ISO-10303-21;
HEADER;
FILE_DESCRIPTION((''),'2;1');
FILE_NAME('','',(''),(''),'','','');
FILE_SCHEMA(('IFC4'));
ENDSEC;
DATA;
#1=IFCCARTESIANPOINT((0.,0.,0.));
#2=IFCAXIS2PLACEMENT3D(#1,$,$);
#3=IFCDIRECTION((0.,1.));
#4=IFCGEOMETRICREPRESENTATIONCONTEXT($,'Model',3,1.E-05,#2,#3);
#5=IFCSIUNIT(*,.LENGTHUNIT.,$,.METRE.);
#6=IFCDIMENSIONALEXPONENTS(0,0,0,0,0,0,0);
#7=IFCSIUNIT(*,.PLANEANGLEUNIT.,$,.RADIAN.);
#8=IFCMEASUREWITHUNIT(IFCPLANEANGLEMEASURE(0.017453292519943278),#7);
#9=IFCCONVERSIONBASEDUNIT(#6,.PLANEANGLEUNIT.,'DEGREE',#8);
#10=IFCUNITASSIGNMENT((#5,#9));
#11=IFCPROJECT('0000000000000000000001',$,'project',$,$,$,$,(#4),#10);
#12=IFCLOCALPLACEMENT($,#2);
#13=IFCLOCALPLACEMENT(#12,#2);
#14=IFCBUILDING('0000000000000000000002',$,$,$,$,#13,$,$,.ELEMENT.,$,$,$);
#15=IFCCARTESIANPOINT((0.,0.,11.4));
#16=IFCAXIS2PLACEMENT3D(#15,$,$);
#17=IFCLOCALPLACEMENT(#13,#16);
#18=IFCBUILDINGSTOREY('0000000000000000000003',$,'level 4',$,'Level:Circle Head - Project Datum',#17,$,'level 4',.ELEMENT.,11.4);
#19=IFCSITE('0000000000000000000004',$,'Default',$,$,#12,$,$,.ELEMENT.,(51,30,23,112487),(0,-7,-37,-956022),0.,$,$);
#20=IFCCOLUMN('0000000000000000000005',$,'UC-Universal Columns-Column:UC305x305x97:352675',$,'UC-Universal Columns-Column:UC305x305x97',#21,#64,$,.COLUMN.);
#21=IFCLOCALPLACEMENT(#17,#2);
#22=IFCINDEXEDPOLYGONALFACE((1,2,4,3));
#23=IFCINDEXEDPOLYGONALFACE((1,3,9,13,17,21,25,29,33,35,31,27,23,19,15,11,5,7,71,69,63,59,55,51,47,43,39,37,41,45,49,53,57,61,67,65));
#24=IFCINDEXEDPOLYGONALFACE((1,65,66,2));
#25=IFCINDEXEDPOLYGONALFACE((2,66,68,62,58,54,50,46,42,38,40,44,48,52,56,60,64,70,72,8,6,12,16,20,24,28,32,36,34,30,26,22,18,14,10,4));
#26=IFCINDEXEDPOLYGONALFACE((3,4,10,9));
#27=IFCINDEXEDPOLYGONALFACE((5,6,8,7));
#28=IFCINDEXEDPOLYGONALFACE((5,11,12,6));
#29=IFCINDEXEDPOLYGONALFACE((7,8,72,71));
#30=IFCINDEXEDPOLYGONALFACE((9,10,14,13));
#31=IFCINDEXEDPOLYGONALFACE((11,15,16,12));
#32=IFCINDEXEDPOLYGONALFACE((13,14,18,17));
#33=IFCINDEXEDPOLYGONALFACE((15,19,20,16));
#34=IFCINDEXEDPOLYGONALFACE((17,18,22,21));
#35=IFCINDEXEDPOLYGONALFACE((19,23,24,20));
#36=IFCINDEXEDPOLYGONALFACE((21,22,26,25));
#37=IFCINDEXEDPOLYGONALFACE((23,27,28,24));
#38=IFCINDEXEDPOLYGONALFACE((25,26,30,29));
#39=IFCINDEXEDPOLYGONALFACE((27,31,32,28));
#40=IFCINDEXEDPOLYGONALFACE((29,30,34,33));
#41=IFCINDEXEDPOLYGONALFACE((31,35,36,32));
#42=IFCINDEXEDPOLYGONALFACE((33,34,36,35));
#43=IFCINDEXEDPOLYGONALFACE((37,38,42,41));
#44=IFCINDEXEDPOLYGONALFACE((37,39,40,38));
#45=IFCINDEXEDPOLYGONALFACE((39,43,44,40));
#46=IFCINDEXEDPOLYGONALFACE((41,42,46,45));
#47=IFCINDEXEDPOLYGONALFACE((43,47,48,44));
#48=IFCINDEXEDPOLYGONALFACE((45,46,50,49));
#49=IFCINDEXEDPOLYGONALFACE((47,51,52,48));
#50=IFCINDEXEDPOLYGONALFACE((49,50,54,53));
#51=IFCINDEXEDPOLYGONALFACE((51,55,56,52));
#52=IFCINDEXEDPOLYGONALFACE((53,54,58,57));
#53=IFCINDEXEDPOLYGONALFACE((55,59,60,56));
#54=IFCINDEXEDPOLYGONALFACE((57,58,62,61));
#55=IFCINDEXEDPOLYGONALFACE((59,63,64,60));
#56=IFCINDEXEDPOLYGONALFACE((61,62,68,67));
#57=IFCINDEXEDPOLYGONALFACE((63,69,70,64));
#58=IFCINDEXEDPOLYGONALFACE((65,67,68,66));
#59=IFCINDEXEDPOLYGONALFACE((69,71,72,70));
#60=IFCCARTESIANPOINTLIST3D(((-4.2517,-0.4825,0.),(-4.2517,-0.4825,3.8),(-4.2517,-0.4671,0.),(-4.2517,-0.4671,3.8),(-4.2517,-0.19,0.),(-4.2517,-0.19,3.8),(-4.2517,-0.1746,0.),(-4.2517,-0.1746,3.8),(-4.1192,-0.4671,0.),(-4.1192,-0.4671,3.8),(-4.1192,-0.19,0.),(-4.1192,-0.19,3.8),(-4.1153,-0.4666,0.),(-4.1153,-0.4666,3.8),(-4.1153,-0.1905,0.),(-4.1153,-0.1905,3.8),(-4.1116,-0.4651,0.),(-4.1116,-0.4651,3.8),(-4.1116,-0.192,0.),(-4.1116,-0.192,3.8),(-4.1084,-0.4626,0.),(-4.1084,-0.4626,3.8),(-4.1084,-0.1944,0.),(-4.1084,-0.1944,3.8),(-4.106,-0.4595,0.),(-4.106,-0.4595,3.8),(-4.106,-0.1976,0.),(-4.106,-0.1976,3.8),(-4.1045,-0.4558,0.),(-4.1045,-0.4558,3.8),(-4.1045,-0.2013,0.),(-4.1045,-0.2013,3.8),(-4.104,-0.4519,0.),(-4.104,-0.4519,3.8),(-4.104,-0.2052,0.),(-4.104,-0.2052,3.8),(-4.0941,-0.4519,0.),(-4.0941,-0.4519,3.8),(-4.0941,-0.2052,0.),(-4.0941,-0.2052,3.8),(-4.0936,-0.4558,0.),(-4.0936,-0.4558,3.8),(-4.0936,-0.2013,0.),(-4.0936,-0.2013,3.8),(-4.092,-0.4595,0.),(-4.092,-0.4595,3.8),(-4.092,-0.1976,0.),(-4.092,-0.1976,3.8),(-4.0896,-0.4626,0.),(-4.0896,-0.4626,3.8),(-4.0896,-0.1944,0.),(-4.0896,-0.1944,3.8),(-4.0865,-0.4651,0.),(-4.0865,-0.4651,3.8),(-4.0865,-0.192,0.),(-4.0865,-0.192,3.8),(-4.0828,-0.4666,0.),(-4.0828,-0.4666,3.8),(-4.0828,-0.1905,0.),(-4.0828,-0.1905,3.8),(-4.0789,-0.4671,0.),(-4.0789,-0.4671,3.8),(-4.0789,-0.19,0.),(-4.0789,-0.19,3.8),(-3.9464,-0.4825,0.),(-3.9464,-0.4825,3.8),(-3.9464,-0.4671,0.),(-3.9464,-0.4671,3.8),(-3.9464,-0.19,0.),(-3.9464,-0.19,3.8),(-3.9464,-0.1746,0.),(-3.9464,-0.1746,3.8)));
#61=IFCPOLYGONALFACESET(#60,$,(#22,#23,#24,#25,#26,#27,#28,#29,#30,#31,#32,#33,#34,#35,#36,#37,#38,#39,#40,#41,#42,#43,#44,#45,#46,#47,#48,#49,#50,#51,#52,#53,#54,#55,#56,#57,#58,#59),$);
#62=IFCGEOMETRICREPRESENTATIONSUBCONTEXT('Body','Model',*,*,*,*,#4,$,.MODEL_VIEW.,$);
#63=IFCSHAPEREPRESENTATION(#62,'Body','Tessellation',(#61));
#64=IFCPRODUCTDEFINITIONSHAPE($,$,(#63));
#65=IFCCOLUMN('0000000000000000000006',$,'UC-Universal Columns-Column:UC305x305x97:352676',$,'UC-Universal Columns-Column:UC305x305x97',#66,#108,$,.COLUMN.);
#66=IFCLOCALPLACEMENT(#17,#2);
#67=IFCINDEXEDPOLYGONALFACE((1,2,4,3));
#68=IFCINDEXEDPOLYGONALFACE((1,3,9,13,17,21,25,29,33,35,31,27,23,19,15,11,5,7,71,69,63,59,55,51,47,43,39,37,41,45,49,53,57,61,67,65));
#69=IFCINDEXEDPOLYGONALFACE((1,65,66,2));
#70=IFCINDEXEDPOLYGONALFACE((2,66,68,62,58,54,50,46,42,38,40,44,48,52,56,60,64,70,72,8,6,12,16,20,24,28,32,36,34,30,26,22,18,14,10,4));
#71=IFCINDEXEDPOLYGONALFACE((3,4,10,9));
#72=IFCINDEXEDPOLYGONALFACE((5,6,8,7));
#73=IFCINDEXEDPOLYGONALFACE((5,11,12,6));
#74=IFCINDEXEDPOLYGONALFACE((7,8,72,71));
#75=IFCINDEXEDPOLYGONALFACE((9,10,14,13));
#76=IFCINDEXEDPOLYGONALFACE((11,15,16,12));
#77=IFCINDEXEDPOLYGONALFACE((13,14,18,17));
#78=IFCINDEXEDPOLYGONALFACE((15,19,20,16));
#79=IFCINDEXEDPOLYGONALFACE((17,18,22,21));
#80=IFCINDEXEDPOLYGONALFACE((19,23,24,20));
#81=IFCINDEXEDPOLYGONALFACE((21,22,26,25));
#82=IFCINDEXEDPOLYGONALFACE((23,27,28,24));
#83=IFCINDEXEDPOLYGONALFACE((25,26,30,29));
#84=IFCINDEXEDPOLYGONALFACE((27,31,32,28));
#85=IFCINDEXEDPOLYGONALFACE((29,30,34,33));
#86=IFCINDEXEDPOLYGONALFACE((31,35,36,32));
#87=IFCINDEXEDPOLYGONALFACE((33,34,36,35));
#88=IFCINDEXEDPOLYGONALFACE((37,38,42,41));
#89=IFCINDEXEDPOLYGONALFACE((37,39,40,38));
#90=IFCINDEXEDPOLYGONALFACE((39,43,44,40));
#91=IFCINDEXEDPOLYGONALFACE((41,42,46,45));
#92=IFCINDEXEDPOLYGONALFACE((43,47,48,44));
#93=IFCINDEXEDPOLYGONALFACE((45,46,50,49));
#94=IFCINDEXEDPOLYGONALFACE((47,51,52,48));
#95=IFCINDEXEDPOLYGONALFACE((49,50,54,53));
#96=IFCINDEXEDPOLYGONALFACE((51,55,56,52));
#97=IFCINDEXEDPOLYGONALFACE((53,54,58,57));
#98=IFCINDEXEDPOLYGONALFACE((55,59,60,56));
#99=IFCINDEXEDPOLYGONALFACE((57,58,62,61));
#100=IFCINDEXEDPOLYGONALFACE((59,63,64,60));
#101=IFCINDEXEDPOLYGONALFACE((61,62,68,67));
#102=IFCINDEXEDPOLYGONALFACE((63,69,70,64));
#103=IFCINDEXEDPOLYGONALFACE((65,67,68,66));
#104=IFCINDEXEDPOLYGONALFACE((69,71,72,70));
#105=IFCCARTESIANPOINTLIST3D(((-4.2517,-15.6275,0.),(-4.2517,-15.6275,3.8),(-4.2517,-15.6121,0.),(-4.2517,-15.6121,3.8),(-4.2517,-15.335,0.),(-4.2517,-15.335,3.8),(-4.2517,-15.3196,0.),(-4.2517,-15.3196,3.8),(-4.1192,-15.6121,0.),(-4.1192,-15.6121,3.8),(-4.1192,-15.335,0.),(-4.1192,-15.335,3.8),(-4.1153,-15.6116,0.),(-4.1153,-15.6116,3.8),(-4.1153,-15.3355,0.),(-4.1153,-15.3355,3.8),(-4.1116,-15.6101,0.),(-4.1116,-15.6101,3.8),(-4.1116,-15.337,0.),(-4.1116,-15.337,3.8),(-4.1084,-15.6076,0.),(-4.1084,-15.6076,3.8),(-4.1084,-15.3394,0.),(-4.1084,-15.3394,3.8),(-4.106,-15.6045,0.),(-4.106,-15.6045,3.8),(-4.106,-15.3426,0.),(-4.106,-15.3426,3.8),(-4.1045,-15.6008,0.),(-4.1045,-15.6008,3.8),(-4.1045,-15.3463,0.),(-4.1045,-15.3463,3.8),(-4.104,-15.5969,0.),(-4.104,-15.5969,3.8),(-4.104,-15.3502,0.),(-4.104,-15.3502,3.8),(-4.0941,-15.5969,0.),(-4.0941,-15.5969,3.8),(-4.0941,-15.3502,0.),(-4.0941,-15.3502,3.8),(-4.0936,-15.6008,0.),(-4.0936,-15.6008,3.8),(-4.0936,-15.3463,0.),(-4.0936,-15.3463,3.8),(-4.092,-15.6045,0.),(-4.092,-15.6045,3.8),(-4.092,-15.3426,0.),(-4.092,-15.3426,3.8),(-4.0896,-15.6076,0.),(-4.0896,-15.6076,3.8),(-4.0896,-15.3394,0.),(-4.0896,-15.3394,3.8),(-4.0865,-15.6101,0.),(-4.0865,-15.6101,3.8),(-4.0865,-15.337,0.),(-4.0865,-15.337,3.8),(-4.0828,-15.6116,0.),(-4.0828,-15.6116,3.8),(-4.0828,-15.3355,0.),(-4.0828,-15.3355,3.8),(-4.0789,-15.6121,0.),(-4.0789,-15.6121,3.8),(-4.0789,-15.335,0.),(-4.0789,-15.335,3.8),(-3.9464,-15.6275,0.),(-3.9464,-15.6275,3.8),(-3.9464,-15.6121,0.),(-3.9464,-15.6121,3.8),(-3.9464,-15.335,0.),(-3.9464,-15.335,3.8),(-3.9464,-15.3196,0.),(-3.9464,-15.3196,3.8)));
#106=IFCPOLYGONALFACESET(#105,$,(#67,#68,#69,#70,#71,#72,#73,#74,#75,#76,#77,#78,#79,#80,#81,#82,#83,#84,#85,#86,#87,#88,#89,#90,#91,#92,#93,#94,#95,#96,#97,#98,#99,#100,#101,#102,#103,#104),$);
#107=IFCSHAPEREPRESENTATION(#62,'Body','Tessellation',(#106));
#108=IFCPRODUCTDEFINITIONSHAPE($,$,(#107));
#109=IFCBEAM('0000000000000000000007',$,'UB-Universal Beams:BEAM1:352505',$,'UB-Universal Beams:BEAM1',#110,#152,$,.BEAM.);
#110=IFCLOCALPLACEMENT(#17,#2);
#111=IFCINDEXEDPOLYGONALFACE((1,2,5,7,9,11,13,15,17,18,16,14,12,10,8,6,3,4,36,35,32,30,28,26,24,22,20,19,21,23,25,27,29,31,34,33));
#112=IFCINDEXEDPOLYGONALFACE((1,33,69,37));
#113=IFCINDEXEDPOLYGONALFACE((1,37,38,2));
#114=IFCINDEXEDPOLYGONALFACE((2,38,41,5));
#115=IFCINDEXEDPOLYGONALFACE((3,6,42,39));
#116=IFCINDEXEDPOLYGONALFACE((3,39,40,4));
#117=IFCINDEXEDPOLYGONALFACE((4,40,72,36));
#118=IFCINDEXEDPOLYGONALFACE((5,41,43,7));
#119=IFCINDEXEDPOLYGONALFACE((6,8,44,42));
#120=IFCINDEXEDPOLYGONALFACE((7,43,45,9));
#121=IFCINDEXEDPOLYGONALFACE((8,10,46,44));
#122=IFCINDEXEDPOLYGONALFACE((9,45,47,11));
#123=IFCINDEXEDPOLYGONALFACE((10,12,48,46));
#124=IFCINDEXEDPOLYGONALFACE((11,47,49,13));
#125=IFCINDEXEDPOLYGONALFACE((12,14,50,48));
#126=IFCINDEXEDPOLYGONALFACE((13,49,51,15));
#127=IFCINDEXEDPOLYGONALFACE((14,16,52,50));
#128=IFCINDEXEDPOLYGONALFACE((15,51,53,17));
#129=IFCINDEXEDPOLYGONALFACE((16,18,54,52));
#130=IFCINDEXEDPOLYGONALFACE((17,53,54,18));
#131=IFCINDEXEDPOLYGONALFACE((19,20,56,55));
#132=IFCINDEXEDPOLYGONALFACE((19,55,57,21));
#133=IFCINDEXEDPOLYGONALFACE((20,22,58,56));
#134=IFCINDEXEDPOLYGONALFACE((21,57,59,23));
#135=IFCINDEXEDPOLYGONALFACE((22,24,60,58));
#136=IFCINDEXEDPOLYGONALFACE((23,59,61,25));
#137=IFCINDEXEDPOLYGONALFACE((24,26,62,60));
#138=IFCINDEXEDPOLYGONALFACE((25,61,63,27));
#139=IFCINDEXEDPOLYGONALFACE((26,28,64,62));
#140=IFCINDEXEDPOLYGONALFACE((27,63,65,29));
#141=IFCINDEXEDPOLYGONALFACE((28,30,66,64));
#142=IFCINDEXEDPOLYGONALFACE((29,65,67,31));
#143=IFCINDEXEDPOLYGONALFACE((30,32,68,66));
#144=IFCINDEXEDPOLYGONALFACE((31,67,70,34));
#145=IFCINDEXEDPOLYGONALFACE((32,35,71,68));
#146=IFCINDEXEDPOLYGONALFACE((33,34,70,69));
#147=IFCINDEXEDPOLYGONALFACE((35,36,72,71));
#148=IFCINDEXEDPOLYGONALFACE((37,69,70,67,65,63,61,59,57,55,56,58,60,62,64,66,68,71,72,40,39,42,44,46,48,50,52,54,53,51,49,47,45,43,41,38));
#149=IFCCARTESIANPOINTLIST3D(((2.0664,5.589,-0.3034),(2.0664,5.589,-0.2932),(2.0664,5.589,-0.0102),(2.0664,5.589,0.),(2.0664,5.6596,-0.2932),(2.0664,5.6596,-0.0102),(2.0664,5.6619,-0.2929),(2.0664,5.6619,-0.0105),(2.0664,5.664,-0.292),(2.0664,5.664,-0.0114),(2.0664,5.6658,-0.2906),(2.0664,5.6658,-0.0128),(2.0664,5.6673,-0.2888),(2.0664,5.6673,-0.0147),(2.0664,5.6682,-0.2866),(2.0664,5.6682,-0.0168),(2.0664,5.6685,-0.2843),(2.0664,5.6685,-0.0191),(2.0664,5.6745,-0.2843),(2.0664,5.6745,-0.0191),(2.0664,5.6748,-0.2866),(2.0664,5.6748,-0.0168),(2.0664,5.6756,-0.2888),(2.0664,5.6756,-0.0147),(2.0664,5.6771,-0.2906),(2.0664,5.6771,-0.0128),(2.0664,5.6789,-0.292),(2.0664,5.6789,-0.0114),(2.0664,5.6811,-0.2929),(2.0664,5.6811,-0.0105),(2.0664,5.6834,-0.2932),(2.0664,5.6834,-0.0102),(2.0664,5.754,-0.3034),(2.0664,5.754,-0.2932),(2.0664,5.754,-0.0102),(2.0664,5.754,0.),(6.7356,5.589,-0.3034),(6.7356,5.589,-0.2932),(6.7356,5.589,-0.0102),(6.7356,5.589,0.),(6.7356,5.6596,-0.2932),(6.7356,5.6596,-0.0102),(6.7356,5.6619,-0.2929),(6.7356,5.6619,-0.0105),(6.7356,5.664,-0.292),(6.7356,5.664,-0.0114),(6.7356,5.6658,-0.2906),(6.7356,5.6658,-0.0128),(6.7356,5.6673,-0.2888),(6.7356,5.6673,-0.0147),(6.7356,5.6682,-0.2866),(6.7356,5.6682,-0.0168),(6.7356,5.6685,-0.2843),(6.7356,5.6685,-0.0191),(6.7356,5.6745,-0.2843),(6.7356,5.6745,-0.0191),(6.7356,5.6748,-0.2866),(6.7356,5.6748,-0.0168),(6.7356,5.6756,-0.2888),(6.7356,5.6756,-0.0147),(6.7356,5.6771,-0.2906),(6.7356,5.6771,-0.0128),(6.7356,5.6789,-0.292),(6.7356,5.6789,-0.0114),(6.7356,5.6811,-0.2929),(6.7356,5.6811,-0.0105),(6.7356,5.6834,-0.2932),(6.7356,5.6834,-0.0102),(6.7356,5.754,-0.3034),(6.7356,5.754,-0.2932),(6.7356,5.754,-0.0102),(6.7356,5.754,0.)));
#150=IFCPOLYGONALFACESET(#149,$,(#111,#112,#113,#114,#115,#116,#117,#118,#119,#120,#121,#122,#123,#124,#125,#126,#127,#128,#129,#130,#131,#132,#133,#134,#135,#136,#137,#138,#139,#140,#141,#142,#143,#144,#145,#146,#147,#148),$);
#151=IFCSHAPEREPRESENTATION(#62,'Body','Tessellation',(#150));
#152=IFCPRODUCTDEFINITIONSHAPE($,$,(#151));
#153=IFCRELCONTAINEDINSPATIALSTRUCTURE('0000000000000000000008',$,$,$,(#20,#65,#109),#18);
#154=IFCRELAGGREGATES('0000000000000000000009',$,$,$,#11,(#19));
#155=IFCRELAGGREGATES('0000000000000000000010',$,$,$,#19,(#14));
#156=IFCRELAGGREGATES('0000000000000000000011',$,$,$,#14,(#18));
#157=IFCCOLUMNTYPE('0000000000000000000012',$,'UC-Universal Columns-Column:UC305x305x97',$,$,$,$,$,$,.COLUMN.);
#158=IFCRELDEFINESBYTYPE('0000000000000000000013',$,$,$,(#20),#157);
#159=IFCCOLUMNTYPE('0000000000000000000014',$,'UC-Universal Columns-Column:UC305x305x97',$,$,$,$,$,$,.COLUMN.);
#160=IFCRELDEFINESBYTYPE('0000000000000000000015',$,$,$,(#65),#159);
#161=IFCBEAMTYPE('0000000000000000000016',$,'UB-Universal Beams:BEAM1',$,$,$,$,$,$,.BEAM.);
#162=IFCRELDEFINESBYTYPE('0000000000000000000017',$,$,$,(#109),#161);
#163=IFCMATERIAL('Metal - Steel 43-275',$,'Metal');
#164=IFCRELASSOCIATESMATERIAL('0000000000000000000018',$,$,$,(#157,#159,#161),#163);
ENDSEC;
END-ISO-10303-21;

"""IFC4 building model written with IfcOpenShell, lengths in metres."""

from ifc_helpers import new_model, entity, si_unit, converted_unit, direction, frame, frame_2d, origin, place, context, subcontext, project, spatial, polyline, circle_curve, parameter, trimmed, segment, composite_curve, i_section, outline, extrude, source, transform, mapped, material, material_profile, profile_set, type_object, type_shapes, element, save


model = new_model("IFC4")

# Units and contexts
model_context = context("Model", 3, precision=1e-05, world=origin(), true_north=direction((0.0, 1.0)))
body_context = subcontext(model_context, "Body", "Model", "MODEL_VIEW")
ifc_project = project(units=[si_unit("LENGTHUNIT", "METRE"), converted_unit("PLANEANGLEUNIT", "DEGREE", entity("IfcPlaneAngleMeasure", 0.017453292519943278), si_unit("PLANEANGLEUNIT", "RADIAN"), dimensions=[0, 0, 0, 0, 0, 0, 0])], contexts=[model_context])

# Site, building, storey
site_placement = place(None, origin())
site = spatial("IfcSite", under=ifc_project, at=site_placement, Name="Default", CompositionType="ELEMENT", RefLatitude=(51, 30, 23, 112487), RefLongitude=(0, -7, -37, -956022), RefElevation=0.0)
building_placement = place(site_placement, origin())
building = spatial("IfcBuilding", under=site, at=building_placement, CompositionType="ELEMENT")
storey_placement = place(building_placement, frame((0.0, 0.0, 11.4)))
storey = spatial("IfcBuildingStorey", under=building, at=storey_placement, Name="level 4", ObjectType="Level:Circle Head - Project Datum", LongName="level 4", CompositionType="ELEMENT", Elevation=11.4)

# Columns
ifc_material_1 = material(Name="Metal - Steel 43-275", Category="Metal")
ifc_material_profile_1 = material_profile(ifc_material_1, i_section(OverallWidth=0.3053, OverallDepth=0.3079, WebThickness=0.0099, FlangeThickness=0.0154, FilletRadius=0.0152, at=frame_2d((0.0, 0.0), x_axis=(1.0, 0.0))), Name="UC305x305x97")
ifc_profile_set_1 = profile_set([ifc_material_profile_1], Name="UC305x305x97")
column_type_1 = type_object("IfcColumnType", Name="UC-Universal Columns-Column:UC305x305x97", PredefinedType="COLUMN", material=ifc_profile_set_1)
shared_shape_1 = source(origin(), body_context, "Body", "SweptSolid", [
    extrude(i_section(OverallWidth=0.3053, OverallDepth=0.3079, WebThickness=0.0099, FlangeThickness=0.0154, FilletRadius=0.0152, at=frame_2d((0.0, 0.0), x_axis=(1.0, 0.0))), frame((-4.099, -0.3285, 11.4), z_axis=(0.0, 0.0, 1.0), x_axis=(-1.0, 0.0, 0.0)), (0.0, 0.0, 1.0), 3.8),
])
type_shapes(column_type_1, [shared_shape_1])
column_1_placement = place(storey_placement, frame((0.0, 0.0, -11.4)))
element("IfcColumn", 1, at=column_1_placement, inside=storey, type_object=column_type_1, Name="UC-Universal Columns-Column:UC305x305x97:352675", ObjectType="UC-Universal Columns-Column:UC305x305x97", PredefinedType="COLUMN", context=body_context, shape_type="MappedRepresentation", body=[
    mapped(shared_shape_1, transform((0.0, 0.0, 0.0), scale=1.0)),
])
column_type_2 = type_object("IfcColumnType", Name="UC-Universal Columns-Column:UC305x305x97", PredefinedType="COLUMN", material=ifc_profile_set_1)
shared_shape_2 = source(origin(), body_context, "Body", "SweptSolid", [
    extrude(i_section(OverallWidth=0.3053, OverallDepth=0.3079, WebThickness=0.0099, FlangeThickness=0.0154, FilletRadius=0.0152, at=frame_2d((0.0, 0.0), x_axis=(1.0, 0.0))), frame((-4.099, -15.4735, 11.4), z_axis=(0.0, 0.0, 1.0), x_axis=(-1.0, 0.0, 0.0)), (0.0, 0.0, 1.0), 3.8),
])
type_shapes(column_type_2, [shared_shape_2])
column_2_placement = place(storey_placement, frame((0.0, 0.0, -11.4)))
element("IfcColumn", 2, at=column_2_placement, inside=storey, type_object=column_type_2, Name="UC-Universal Columns-Column:UC305x305x97:352676", ObjectType="UC-Universal Columns-Column:UC305x305x97", PredefinedType="COLUMN", context=body_context, shape_type="MappedRepresentation", body=[
    mapped(shared_shape_2, transform((0.0, 0.0, 0.0), scale=1.0)),
])

# Beam
ifc_material_profile_2 = material_profile(ifc_material_1, outline(composite_curve([segment(polyline([(-0.0825, -0.1415), (-0.0825, -0.1517)]), True, "CONTINUOUS"), segment(polyline([(-0.0825, -0.1517), (0.0825, -0.1517)]), True, "CONTINUOUS"), segment(polyline([(0.0825, -0.1517), (0.0825, -0.1415)]), True, "CONTINUOUS"), segment(polyline([(0.0825, -0.1415), (0.0119, -0.1415)]), True, "CONTINUOUS"), segment(trimmed(circle_curve(frame_2d((0.0119, -0.1326), x_axis=(1.0, 0.0)), 0.0089), [parameter(180.0)], [parameter(270.0)], True, "PARAMETER"), False, "CONTINUOUS"), segment(polyline([(0.003, -0.1326), (0.003, 0.1326)]), True, "CONTINUOUS"), segment(trimmed(circle_curve(frame_2d((0.0119, 0.1326), x_axis=(1.0, 0.0)), 0.0089), [parameter(90.0)], [parameter(180.0)], True, "PARAMETER"), False, "CONTINUOUS"), segment(polyline([(0.0119, 0.1415), (0.0825, 0.1415)]), True, "CONTINUOUS"), segment(polyline([(0.0825, 0.1415), (0.0825, 0.1517)]), True, "CONTINUOUS"), segment(polyline([(0.0825, 0.1517), (-0.0825, 0.1517)]), True, "CONTINUOUS"), segment(polyline([(-0.0825, 0.1517), (-0.0825, 0.1415)]), True, "CONTINUOUS"), segment(polyline([(-0.0825, 0.1415), (-0.0119, 0.1415)]), True, "CONTINUOUS"), segment(trimmed(circle_curve(frame_2d((-0.0119, 0.1326), x_axis=(1.0, 0.0)), 0.0089), [parameter(360.0)], [parameter(90.0)], True, "PARAMETER"), False, "CONTINUOUS"), segment(polyline([(-0.003, 0.1326), (-0.003, -0.1326)]), True, "CONTINUOUS"), segment(trimmed(circle_curve(frame_2d((-0.0119, -0.1326), x_axis=(1.0, 0.0)), 0.0089), [parameter(270.0)], [parameter(360.0)], True, "PARAMETER"), False, "CONTINUOUS"), segment(polyline([(-0.0119, -0.1415), (-0.0825, -0.1415)]), True, "CONTINUOUS")], self_intersect=False)), Name="BEAM1")
ifc_profile_set_2 = profile_set([ifc_material_profile_2], Name="BEAM1")
beam_type_1 = type_object("IfcBeamType", Name="UB-Universal Beams:BEAM1", PredefinedType="BEAM", material=ifc_profile_set_2)
shared_shape_3 = source(origin(), body_context, "Body", "SweptSolid", [
    extrude(outline(composite_curve([segment(polyline([(-0.0825, -0.1415), (-0.0825, -0.1517)]), True, "CONTINUOUS"), segment(polyline([(-0.0825, -0.1517), (0.0825, -0.1517)]), True, "CONTINUOUS"), segment(polyline([(0.0825, -0.1517), (0.0825, -0.1415)]), True, "CONTINUOUS"), segment(polyline([(0.0825, -0.1415), (0.0119, -0.1415)]), True, "CONTINUOUS"), segment(trimmed(circle_curve(frame_2d((0.0119, -0.1326), x_axis=(1.0, 0.0)), 0.0089), [parameter(180.0)], [parameter(270.0)], True, "PARAMETER"), False, "CONTINUOUS"), segment(polyline([(0.003, -0.1326), (0.003, 0.1326)]), True, "CONTINUOUS"), segment(trimmed(circle_curve(frame_2d((0.0119, 0.1326), x_axis=(1.0, 0.0)), 0.0089), [parameter(90.0)], [parameter(180.0)], True, "PARAMETER"), False, "CONTINUOUS"), segment(polyline([(0.0119, 0.1415), (0.0825, 0.1415)]), True, "CONTINUOUS"), segment(polyline([(0.0825, 0.1415), (0.0825, 0.1517)]), True, "CONTINUOUS"), segment(polyline([(0.0825, 0.1517), (-0.0825, 0.1517)]), True, "CONTINUOUS"), segment(polyline([(-0.0825, 0.1517), (-0.0825, 0.1415)]), True, "CONTINUOUS"), segment(polyline([(-0.0825, 0.1415), (-0.0119, 0.1415)]), True, "CONTINUOUS"), segment(trimmed(circle_curve(frame_2d((-0.0119, 0.1326), x_axis=(1.0, 0.0)), 0.0089), [parameter(360.0)], [parameter(90.0)], True, "PARAMETER"), False, "CONTINUOUS"), segment(polyline([(-0.003, 0.1326), (-0.003, -0.1326)]), True, "CONTINUOUS"), segment(trimmed(circle_curve(frame_2d((-0.0119, -0.1326), x_axis=(1.0, 0.0)), 0.0089), [parameter(270.0)], [parameter(360.0)], True, "PARAMETER"), False, "CONTINUOUS"), segment(polyline([(-0.0119, -0.1415), (-0.0825, -0.1415)]), True, "CONTINUOUS")], self_intersect=False)), frame((-2.3346, 0.0, 0.0), z_axis=(-1.0, 0.0, 0.0), x_axis=(0.0, -1.0, 0.0)), (0.0, 0.0, -1.0), 4.6692),
])
type_shapes(beam_type_1, [shared_shape_3])
for number, where, name in (
    (3, (4.401, 5.6715, -0.1517), "UB-Universal Beams:BEAM1:352505"),
):
    element("IfcBeam", number, at=place(storey_placement, frame(where)), inside=storey, type_object=beam_type_1, Name=name, ObjectType="UB-Universal Beams:BEAM1", PredefinedType="BEAM", context=body_context, shape_type="MappedRepresentation", body=[
        mapped(shared_shape_3, transform((0.0, 0.0, 0.0), scale=1.0)),
    ])

save(model, "model.ifc")
